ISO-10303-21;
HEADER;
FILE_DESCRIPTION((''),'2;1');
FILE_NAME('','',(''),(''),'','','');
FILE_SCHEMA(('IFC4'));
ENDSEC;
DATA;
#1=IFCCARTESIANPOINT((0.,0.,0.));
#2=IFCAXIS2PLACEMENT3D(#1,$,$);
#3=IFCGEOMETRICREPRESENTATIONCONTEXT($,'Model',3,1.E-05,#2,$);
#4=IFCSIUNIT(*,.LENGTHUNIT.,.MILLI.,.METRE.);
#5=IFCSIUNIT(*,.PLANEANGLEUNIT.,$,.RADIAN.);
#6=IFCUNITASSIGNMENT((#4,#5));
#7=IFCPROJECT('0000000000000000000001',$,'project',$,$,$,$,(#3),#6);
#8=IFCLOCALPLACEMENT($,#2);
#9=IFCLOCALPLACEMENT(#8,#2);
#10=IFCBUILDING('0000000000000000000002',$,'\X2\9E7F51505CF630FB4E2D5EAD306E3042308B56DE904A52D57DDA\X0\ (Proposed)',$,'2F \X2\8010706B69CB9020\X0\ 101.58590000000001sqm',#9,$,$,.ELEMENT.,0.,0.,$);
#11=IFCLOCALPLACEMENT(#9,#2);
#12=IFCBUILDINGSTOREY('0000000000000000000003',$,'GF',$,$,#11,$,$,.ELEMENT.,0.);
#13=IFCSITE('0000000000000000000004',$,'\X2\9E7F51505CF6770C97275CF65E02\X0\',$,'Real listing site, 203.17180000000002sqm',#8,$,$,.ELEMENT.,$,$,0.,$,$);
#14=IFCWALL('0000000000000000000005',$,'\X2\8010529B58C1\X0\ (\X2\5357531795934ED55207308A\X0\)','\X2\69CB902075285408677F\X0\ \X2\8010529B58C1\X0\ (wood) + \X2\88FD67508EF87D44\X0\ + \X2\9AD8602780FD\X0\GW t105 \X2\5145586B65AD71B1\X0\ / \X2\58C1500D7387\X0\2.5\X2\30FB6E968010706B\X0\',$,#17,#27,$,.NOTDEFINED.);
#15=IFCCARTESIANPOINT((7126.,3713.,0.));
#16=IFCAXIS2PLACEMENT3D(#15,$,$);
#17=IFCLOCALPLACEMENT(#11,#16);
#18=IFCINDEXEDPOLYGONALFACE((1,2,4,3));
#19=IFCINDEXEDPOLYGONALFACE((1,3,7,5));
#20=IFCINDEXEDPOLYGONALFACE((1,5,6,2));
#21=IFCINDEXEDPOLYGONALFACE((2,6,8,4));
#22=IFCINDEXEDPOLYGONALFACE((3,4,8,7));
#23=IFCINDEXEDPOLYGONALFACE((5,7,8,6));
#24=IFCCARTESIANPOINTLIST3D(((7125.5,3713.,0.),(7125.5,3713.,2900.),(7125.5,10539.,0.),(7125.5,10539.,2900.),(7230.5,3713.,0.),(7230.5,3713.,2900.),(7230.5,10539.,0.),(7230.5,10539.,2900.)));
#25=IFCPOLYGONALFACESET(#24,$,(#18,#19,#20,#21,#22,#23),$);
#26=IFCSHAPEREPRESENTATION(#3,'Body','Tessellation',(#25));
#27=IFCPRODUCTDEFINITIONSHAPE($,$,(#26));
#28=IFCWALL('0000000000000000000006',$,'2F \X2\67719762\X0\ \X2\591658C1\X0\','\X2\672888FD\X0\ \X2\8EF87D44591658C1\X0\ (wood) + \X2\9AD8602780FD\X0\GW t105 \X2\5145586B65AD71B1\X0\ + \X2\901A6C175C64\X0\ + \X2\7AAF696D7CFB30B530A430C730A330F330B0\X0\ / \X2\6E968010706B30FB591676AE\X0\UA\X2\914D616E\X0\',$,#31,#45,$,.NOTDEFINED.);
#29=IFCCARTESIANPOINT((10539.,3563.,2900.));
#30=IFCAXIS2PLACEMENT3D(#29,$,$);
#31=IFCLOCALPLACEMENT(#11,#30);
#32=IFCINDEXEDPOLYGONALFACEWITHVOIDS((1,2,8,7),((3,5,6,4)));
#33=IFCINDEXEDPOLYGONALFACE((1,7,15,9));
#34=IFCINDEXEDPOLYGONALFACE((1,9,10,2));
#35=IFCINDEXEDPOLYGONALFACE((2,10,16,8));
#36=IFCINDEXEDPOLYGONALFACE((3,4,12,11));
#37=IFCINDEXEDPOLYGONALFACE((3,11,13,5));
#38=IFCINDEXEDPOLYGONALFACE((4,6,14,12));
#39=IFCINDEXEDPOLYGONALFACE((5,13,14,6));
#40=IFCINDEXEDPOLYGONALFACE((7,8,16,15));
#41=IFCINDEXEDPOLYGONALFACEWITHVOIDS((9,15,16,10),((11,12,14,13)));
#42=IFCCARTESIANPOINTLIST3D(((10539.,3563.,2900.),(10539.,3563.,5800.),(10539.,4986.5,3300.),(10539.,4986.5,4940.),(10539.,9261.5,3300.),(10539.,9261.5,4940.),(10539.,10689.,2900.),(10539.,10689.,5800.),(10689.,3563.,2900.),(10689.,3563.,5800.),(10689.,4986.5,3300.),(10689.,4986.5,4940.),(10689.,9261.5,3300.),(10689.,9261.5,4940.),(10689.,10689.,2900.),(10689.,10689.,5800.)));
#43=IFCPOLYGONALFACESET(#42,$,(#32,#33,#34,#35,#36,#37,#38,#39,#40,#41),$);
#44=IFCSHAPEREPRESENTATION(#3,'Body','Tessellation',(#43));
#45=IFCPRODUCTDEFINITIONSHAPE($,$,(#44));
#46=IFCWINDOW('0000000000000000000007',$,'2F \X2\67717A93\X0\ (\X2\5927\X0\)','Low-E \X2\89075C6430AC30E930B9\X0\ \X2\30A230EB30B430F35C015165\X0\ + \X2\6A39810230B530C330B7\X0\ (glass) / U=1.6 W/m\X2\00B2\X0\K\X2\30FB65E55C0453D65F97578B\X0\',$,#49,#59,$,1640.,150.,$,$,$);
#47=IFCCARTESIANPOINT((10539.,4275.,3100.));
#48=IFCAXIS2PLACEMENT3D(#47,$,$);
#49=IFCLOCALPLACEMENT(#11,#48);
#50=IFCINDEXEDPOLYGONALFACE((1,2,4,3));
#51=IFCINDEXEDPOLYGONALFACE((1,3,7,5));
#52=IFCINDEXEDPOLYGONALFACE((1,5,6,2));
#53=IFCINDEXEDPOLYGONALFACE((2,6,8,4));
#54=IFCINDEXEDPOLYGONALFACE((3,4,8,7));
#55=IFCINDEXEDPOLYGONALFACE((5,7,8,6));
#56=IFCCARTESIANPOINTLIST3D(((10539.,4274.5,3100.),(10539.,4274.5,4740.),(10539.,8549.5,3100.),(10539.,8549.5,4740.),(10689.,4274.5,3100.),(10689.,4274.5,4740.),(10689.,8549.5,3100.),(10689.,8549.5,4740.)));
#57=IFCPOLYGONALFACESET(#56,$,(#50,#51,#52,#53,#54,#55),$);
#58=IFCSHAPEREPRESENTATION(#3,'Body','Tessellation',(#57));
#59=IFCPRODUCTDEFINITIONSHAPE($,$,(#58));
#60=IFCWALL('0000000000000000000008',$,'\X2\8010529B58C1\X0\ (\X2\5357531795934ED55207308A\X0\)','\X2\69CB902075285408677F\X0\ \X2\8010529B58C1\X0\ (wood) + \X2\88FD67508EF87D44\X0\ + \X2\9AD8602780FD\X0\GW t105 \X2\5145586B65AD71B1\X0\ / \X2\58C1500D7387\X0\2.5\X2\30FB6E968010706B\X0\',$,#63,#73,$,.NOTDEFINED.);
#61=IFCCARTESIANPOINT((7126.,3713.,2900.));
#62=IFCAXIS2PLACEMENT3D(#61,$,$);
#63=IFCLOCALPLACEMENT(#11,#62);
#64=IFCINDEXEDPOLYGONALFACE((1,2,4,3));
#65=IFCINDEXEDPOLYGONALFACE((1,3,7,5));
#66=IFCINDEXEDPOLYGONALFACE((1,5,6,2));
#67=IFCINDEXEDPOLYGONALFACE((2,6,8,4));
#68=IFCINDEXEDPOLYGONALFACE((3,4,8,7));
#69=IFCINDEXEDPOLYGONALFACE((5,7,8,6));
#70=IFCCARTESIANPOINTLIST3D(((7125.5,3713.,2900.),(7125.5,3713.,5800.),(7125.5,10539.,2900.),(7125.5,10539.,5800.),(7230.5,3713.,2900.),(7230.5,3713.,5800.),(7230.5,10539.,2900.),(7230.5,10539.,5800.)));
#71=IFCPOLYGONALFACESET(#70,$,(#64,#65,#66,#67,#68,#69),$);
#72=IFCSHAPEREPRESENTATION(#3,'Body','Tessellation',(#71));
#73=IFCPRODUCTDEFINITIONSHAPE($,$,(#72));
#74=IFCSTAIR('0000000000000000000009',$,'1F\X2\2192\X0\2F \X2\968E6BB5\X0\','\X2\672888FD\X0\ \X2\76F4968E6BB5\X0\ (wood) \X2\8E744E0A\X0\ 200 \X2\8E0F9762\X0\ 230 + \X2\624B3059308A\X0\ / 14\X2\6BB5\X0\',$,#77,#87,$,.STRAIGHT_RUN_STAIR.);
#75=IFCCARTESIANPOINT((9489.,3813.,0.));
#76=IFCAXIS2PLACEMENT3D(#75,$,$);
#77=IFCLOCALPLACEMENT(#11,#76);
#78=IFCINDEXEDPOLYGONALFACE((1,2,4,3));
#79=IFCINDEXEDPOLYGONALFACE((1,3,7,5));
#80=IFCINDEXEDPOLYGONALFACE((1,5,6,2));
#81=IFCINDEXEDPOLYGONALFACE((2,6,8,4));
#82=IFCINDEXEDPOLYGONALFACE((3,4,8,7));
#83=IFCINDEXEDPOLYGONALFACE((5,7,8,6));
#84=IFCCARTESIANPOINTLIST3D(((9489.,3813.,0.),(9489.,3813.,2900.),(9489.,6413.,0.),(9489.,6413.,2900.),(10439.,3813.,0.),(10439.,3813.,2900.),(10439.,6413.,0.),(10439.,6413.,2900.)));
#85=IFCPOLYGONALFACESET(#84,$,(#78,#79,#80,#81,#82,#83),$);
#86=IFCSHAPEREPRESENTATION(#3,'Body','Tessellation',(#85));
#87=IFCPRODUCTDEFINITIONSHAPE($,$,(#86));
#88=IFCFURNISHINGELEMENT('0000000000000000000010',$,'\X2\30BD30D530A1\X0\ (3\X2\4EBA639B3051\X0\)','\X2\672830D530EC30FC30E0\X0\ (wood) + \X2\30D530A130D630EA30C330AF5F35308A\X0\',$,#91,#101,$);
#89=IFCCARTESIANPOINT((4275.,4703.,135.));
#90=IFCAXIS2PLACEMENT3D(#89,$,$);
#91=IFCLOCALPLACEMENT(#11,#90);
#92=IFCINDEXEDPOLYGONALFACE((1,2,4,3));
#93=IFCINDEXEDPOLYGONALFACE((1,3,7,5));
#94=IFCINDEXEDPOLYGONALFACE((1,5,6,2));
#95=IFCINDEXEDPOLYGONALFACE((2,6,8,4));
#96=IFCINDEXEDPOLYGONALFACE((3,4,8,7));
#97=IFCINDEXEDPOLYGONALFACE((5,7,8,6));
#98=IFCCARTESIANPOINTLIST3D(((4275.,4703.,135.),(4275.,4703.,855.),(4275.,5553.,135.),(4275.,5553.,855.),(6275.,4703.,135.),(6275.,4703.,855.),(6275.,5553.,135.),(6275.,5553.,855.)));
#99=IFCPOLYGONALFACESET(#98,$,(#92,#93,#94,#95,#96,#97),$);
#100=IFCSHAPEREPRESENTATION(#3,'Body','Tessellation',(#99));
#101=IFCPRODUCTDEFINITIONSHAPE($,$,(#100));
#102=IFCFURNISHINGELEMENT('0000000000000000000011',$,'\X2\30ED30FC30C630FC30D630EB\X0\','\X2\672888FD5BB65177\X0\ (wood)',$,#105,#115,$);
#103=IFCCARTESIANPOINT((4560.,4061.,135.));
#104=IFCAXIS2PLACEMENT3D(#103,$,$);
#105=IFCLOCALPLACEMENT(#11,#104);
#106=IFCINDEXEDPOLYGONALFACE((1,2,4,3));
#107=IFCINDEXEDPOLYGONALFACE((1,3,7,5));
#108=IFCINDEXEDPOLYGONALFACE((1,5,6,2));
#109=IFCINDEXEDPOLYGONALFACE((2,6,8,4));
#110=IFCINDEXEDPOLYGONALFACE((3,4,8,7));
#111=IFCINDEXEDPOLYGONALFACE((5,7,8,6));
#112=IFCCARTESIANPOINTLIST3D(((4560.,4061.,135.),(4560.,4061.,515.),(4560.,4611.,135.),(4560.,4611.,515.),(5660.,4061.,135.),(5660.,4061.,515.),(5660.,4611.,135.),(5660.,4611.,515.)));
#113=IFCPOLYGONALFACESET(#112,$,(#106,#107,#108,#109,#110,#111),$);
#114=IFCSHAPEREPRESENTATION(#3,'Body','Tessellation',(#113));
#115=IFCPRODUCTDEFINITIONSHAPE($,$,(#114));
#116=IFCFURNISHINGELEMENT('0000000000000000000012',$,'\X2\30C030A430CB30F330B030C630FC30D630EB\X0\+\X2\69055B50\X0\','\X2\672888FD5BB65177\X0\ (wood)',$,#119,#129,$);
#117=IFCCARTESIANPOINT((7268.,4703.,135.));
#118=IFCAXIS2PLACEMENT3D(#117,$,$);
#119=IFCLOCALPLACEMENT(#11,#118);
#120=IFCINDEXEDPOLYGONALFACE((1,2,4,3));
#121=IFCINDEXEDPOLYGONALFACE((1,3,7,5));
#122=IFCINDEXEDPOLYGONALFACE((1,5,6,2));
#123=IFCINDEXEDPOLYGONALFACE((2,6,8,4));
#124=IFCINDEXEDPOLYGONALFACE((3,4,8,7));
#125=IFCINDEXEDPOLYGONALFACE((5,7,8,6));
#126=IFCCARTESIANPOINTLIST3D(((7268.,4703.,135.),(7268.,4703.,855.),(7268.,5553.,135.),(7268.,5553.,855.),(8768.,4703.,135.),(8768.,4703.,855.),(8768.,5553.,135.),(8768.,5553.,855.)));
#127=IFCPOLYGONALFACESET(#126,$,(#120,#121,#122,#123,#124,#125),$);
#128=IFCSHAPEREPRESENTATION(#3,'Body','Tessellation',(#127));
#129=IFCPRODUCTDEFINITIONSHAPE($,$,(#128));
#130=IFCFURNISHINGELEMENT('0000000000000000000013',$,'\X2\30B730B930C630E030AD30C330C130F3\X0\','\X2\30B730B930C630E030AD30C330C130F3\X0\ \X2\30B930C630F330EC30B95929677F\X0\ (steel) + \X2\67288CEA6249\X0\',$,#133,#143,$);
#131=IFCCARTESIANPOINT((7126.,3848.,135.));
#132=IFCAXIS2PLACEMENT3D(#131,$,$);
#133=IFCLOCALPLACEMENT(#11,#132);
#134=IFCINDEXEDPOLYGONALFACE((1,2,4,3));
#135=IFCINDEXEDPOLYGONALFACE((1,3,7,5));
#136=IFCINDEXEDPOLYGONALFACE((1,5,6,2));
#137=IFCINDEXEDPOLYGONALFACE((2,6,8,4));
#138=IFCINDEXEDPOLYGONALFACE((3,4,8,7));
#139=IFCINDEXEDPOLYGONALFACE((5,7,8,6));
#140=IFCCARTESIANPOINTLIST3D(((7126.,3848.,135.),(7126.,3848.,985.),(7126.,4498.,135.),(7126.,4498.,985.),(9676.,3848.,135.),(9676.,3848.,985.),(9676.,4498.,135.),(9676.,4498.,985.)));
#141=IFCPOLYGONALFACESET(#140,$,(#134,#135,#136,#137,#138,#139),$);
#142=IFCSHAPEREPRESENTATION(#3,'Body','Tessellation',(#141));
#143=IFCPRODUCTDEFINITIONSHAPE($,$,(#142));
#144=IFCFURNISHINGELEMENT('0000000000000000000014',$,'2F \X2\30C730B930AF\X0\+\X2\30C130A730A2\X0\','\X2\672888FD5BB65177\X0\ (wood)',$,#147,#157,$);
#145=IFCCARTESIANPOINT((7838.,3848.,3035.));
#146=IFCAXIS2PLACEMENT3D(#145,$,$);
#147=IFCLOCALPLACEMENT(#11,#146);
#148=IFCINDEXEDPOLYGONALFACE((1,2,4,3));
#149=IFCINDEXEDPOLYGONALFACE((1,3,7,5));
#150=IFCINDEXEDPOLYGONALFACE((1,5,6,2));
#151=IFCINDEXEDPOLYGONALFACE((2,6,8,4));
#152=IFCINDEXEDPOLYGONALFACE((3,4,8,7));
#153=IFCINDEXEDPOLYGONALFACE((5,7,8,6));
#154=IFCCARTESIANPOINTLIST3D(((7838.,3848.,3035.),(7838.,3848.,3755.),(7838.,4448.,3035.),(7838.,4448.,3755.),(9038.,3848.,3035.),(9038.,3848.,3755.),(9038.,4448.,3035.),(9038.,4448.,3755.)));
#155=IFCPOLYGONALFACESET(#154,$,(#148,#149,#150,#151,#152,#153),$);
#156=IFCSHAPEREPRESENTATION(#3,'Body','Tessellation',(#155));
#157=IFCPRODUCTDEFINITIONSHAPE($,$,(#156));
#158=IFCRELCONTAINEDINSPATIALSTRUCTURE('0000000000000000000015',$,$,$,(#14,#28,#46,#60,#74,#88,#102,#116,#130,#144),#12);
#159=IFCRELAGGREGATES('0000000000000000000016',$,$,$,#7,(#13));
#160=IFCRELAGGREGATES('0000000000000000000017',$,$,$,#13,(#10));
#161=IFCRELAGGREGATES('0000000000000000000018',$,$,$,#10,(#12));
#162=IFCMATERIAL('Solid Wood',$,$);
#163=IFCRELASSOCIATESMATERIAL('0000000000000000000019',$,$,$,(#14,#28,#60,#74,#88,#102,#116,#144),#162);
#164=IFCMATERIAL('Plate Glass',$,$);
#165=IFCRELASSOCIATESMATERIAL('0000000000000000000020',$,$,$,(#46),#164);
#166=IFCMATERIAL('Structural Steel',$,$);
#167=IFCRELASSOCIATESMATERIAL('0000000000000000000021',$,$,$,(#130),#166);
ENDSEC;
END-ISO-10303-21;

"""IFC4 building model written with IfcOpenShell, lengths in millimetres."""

from ifc_helpers import new_model, si_unit, frame, frame_2d, origin, place, context, project, spatial, rectangle, extrude, material, element, fill, save


model = new_model("IFC4")

# Units and contexts
model_context = context("Model", 3, precision=1e-05, world=origin())
ifc_project = project(units=[si_unit("LENGTHUNIT", "METRE", prefix="MILLI"), si_unit("PLANEANGLEUNIT", "RADIAN")], contexts=[model_context])

# Site, building, storey
site_placement = place(None, origin())
site = spatial("IfcSite", under=ifc_project, at=site_placement, Name="鹿児島県霧島市", ObjectType="Real listing site, 203.17180000000002sqm", CompositionType="ELEMENT", RefElevation=0.0)
building_placement = place(site_placement, origin())
building = spatial("IfcBuilding", under=site, at=building_placement, Name="鹿児島・中庭のある回遊動線 (Proposed)", ObjectType="2F 耐火構造 101.58590000000001sqm", CompositionType="ELEMENT", ElevationOfRefHeight=0.0, ElevationOfTerrain=0.0)
storey_placement = place(building_placement, origin())
storey = spatial("IfcBuildingStorey", under=building, at=storey_placement, Name="GF", CompositionType="ELEMENT", Elevation=0.0)

# Shared definitions
ifc_material_1 = material(Name="Solid Wood")
ifc_material_2 = material(Name="Plate Glass")

# Wall
wall_1_placement = place(storey_placement, frame((7126.0, 3713.0, 0.0)))
element("IfcWall", 1, at=wall_1_placement, inside=storey, material=ifc_material_1, Name="耐力壁 (南北間仕切り)", Description="構造用合板 耐力壁 (wood) + 製材軸組 + 高性能GW t105 充填断熱 / 壁倍率2.5・準耐火", PredefinedType="NOTDEFINED", context=model_context, shape_type="SweptSolid", body=[
    extrude(rectangle(XDim=105.0, YDim=6826.0, at=frame_2d((52.0, 3413.0))), frame((7126.0, 3713.0, 0.0)), (0.0, 0.0, 1.0), 2900.0),
])

# Wall, opening, window
wall_2_placement = place(storey_placement, frame((10539.0, 3563.0, 2900.0)))
wall_2 = element("IfcWall", 2, at=wall_2_placement, inside=storey, material=ifc_material_1, Name="2F 東面 外壁", Description="木製 軸組外壁 (wood) + 高性能GW t105 充填断熱 + 通気層 + 窯業系サイディング / 準耐火・外皮UA配慮", PredefinedType="NOTDEFINED", context=model_context, shape_type="SweptSolid", body=[
    extrude(rectangle(XDim=150.0, YDim=7126.0, at=frame_2d((75.0, 3563.0))), frame((10539.0, 3563.0, 2900.0)), (0.0, 0.0, 1.0), 2900.0),
])
opening_1_placement = place(storey_placement, frame((10539.0, 4275.0, 3100.0)))
opening_1 = element("IfcOpeningElement", 3, at=opening_1_placement, cuts=wall_2, PredefinedType="NOTDEFINED", context=model_context, shape_type="SweptSolid", body=[
    extrude(rectangle(XDim=150.0, YDim=4275.0, at=frame_2d((75.0, 2137.0))), frame((10539.0, 4275.0, 3100.0)), (0.0, 0.0, 1.0), 1640.0),
])
window_1_placement = place(storey_placement, frame((10539.0, 4275.0, 3100.0)))
window_1 = element("IfcWindow", 4, at=window_1_placement, inside=storey, material=ifc_material_2, Name="2F 東窓 (大)", Description="Low-E 複層ガラス アルゴン封入 + 樹脂サッシ (glass) / U=1.6 W/m²K・日射取得型", OverallHeight=1640.0, OverallWidth=150.0, context=model_context, shape_type="SweptSolid", body=[
    extrude(rectangle(XDim=150.0, YDim=4275.0, at=frame_2d((75.0, 2137.0))), frame((10539.0, 4275.0, 3100.0)), (0.0, 0.0, 1.0), 1640.0),
])
fill(opening_1, window_1)

# Wall
wall_3_placement = place(storey_placement, frame((7126.0, 3713.0, 2900.0)))
element("IfcWall", 5, at=wall_3_placement, inside=storey, material=ifc_material_1, Name="耐力壁 (南北間仕切り)", Description="構造用合板 耐力壁 (wood) + 製材軸組 + 高性能GW t105 充填断熱 / 壁倍率2.5・準耐火", PredefinedType="NOTDEFINED", context=model_context, shape_type="SweptSolid", body=[
    extrude(rectangle(XDim=105.0, YDim=6826.0, at=frame_2d((52.0, 3413.0))), frame((7126.0, 3713.0, 2900.0)), (0.0, 0.0, 1.0), 2900.0),
])

# Stair
stair_placement = place(storey_placement, frame((9489.0, 3813.0, 0.0)))
element("IfcStair", 6, at=stair_placement, inside=storey, material=ifc_material_1, Name="1F→2F 階段", Description="木製 直階段 (wood) 蹴上 200 踏面 230 + 手すり / 14段", PredefinedType="STRAIGHT_RUN_STAIR", context=model_context, shape_type="SweptSolid", body=[
    extrude(rectangle(XDim=950.0, YDim=2600.0, at=frame_2d((475.0, 1300.0))), frame((9489.0, 3813.0, 0.0)), (0.0, 0.0, 1.0), 2900.0),
])

# Furnishing elements
furnishing_1_placement = place(storey_placement, frame((4275.0, 4703.0, 135.0)))
element("IfcFurnishingElement", 7, at=furnishing_1_placement, inside=storey, material=ifc_material_1, Name="ソファ (3人掛け)", Description="木フレーム (wood) + ファブリック張り", context=model_context, shape_type="SweptSolid", body=[
    extrude(rectangle(XDim=2000.0, YDim=850.0, at=frame_2d((1000.0, 425.0))), frame((4275.0, 4703.0, 135.0)), (0.0, 0.0, 1.0), 720.0),
])
furnishing_2_placement = place(storey_placement, frame((4560.0, 4061.0, 135.0)))
element("IfcFurnishingElement", 8, at=furnishing_2_placement, inside=storey, material=ifc_material_1, Name="ローテーブル", Description="木製家具 (wood)", context=model_context, shape_type="SweptSolid", body=[
    extrude(rectangle(XDim=1100.0, YDim=550.0, at=frame_2d((550.0, 275.0))), frame((4560.0, 4061.0, 135.0)), (0.0, 0.0, 1.0), 380.0),
])
furnishing_3_placement = place(storey_placement, frame((7268.0, 4703.0, 135.0)))
element("IfcFurnishingElement", 9, at=furnishing_3_placement, inside=storey, material=ifc_material_1, Name="ダイニングテーブル+椅子", Description="木製家具 (wood)", context=model_context, shape_type="SweptSolid", body=[
    extrude(rectangle(XDim=1500.0, YDim=850.0, at=frame_2d((750.0, 425.0))), frame((7268.0, 4703.0, 135.0)), (0.0, 0.0, 1.0), 720.0),
])
ifc_material_3 = material(Name="Structural Steel")
furnishing_4_placement = place(storey_placement, frame((7126.0, 3848.0, 135.0)))
element("IfcFurnishingElement", 10, at=furnishing_4_placement, inside=storey, material=ifc_material_3, Name="システムキッチン", Description="システムキッチン ステンレス天板 (steel) + 木質扉", context=model_context, shape_type="SweptSolid", body=[
    extrude(rectangle(XDim=2550.0, YDim=650.0, at=frame_2d((1275.0, 325.0))), frame((7126.0, 3848.0, 135.0)), (0.0, 0.0, 1.0), 850.0),
])
furnishing_5_placement = place(storey_placement, frame((7838.0, 3848.0, 3035.0)))
element("IfcFurnishingElement", 11, at=furnishing_5_placement, inside=storey, material=ifc_material_1, Name="2F デスク+チェア", Description="木製家具 (wood)", context=model_context, shape_type="SweptSolid", body=[
    extrude(rectangle(XDim=1200.0, YDim=600.0, at=frame_2d((600.0, 300.0))), frame((7838.0, 3848.0, 3035.0)), (0.0, 0.0, 1.0), 720.0),
])

save(model, "model.ifc")
